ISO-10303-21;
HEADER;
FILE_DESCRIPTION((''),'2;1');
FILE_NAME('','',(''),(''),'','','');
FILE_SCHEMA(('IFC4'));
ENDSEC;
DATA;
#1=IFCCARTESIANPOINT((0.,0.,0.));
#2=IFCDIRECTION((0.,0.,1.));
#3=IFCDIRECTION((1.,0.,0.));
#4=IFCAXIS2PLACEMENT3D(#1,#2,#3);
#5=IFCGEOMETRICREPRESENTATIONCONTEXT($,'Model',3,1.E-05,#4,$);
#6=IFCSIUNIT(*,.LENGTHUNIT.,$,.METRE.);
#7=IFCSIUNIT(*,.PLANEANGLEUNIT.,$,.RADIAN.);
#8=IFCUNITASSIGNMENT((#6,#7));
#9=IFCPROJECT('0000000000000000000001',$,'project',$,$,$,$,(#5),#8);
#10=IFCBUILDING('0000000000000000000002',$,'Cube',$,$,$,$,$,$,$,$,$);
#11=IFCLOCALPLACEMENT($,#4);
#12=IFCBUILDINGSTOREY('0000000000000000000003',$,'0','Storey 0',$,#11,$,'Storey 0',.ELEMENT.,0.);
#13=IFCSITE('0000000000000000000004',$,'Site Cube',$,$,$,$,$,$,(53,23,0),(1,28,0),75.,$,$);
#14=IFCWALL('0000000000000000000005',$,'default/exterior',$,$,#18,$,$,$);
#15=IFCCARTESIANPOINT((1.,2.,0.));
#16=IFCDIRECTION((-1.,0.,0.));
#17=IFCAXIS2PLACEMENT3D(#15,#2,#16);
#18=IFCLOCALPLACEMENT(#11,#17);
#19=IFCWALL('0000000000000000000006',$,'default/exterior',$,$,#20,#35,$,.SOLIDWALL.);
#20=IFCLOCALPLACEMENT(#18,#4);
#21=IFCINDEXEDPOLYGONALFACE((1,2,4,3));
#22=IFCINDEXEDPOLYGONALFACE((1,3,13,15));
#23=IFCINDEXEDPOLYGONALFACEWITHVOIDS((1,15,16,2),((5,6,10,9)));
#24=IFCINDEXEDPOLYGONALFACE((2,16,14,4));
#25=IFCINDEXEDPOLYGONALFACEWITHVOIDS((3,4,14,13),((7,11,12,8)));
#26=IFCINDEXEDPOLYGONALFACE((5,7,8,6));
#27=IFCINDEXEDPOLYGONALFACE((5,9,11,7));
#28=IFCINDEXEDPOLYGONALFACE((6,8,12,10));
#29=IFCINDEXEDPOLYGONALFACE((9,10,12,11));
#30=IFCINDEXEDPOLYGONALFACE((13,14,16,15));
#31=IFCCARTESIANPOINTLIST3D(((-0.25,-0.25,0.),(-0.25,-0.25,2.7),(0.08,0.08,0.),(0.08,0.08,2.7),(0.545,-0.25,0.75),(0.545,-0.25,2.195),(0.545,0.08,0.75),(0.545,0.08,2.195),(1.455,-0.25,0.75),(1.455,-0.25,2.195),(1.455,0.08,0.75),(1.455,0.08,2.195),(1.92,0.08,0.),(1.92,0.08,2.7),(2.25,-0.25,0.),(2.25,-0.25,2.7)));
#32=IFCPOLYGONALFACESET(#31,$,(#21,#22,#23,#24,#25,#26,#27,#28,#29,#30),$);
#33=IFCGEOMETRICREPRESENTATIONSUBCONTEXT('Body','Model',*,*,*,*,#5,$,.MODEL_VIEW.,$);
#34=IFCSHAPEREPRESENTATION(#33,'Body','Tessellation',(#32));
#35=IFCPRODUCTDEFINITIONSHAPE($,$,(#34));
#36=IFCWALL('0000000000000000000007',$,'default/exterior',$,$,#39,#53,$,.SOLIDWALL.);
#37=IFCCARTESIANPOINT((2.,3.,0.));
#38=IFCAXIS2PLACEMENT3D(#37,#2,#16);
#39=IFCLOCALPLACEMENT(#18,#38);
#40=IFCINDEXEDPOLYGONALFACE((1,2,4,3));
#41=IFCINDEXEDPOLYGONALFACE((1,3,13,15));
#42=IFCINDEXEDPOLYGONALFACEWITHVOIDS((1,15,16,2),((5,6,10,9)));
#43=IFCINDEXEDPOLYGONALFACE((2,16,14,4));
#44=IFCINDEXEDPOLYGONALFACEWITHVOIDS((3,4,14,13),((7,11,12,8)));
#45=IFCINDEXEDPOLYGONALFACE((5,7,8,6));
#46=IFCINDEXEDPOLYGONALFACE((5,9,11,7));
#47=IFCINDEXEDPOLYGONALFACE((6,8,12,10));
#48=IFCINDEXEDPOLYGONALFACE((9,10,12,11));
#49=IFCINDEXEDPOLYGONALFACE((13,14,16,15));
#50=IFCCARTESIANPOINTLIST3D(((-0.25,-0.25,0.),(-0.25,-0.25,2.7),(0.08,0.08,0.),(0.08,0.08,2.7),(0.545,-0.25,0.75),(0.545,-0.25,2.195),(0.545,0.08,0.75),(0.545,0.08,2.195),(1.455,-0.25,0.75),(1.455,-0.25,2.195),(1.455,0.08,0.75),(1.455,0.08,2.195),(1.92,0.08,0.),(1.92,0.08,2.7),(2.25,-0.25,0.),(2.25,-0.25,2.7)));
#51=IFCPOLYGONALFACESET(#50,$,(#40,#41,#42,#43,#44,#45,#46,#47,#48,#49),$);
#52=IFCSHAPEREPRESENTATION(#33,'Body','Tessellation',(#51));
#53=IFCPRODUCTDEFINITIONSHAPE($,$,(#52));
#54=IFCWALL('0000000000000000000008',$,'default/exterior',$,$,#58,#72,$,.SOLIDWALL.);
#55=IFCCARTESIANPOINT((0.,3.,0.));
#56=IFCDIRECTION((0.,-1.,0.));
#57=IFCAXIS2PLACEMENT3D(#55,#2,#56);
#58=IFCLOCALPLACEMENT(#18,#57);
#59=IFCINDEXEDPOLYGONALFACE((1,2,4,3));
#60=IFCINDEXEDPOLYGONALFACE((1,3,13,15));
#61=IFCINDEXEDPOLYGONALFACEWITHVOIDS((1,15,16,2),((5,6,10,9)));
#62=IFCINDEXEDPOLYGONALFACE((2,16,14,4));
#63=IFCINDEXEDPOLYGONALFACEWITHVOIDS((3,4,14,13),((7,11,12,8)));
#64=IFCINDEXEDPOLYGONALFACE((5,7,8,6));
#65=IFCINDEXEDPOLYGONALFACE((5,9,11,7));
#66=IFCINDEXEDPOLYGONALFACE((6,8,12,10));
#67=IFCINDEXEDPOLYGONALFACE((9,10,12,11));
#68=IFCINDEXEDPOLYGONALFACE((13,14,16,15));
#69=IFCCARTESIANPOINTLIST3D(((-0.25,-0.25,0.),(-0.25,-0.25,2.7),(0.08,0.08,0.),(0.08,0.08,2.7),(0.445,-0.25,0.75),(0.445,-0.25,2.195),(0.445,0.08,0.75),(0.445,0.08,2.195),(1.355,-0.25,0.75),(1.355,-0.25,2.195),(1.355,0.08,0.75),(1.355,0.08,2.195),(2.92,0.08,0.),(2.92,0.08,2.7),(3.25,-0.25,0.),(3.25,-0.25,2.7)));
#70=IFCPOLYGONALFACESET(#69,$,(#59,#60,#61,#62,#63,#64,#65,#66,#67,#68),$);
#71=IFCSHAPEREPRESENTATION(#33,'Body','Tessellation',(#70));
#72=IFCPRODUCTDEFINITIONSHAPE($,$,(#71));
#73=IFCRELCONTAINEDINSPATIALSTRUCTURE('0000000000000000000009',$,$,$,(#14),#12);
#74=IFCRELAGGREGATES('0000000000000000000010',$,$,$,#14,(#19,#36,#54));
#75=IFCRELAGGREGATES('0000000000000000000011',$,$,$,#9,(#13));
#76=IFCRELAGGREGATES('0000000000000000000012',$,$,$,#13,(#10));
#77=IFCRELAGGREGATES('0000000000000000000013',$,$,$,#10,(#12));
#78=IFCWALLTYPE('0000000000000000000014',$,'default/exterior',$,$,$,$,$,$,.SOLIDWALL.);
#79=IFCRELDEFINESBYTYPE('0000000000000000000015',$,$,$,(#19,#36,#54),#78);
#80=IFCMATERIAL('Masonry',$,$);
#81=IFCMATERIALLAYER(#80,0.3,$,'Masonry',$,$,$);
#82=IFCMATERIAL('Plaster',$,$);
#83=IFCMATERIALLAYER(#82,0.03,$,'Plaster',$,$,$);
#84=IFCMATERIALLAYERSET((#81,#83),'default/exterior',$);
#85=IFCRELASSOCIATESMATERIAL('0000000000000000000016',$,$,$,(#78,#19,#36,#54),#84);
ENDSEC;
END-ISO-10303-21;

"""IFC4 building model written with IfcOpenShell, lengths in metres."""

from ifc_helpers import new_model, si_unit, frame, origin, origin_with_axes, place, context, subcontext, project, spatial, polyline, outline, extrude, material, layer, layer_set, layer_usage, type_object, element, aggregate, save


model = new_model("IFC4")

# Units and contexts
model_context = context("Model", 3, precision=1e-05, world=origin_with_axes())
body_context = subcontext(model_context, "Body", "Model", "MODEL_VIEW")
ifc_project = project(units=[si_unit("LENGTHUNIT", "METRE"), si_unit("PLANEANGLEUNIT", "RADIAN")], contexts=[model_context])

# Site, building, storey
site = spatial("IfcSite", under=ifc_project, Name="Site Cube", RefLatitude=(53, 23, 0), RefLongitude=(1, 28, 0), RefElevation=75.0)
building = spatial("IfcBuilding", under=site, Name="Cube")
storey_placement = place(None, origin_with_axes())
storey = spatial("IfcBuildingStorey", under=building, at=storey_placement, Name="0", Description="Storey 0", LongName="Storey 0", CompositionType="ELEMENT", Elevation=0.0)

# Walls, openings
wall_1_placement = place(storey_placement, frame((1.0, 2.0, 0.0), z_axis=(0.0, 0.0, 1.0), x_axis=(-1.0, 0.0, 0.0)))
wall_1 = element("IfcWall", 1, at=wall_1_placement, inside=storey, Name="default/exterior")
ifc_material_1 = material(Name="Masonry")
ifc_layer_1 = layer(ifc_material_1, 0.3, Name="Masonry")
ifc_material_2 = material(Name="Plaster")
ifc_layer_2 = layer(ifc_material_2, 0.03, Name="Plaster")
ifc_layer_set_1 = layer_set([ifc_layer_1, ifc_layer_2], Name="default/exterior")
ifc_layer_usage_1 = layer_usage(ifc_layer_set_1, "AXIS2", "POSITIVE", -0.25)
wall_type = type_object("IfcWallType", Name="default/exterior", PredefinedType="SOLIDWALL", material=ifc_layer_set_1)
wall_2_placement = place(wall_1_placement, origin_with_axes())
wall_2 = element("IfcWall", 2, at=wall_2_placement, type_object=wall_type, material=ifc_layer_usage_1, Name="default/exterior", PredefinedType="SOLIDWALL", context=body_context, shape_type="SweptSolid", body=[
    extrude(outline(polyline([(0.08, 0.08), (-0.25, -0.25), (2.25, -0.25), (1.92, 0.08), (0.08, 0.08)])), origin(), (0.0, 0.0, 1.0), 2.7),
])
opening_1_placement = place(None, frame((0.455, 2.25, 0.75), z_axis=(0.0, 0.0, 1.0), x_axis=(-1.0, 0.0, 0.0)))
element("IfcOpeningElement", 3, at=opening_1_placement, cuts=wall_2, PredefinedType="OPENING", context=body_context, shape_type="SweptSolid", body=[
    extrude(outline(polyline([(0.0, -0.02), (0.91, -0.02), (0.91, 0.35), (0.0, 0.35), (0.0, -0.02)])), origin(), (0.0, 0.0, 1.0), 1.445),
])
ifc_layer_usage_2 = layer_usage(ifc_layer_set_1, "AXIS2", "POSITIVE", -0.25)
wall_3_placement = place(wall_1_placement, frame((2.0, 3.0, 0.0), z_axis=(0.0, 0.0, 1.0), x_axis=(-1.0, 0.0, 0.0)))
wall_3 = element("IfcWall", 4, at=wall_3_placement, type_object=wall_type, material=ifc_layer_usage_2, Name="default/exterior", PredefinedType="SOLIDWALL", context=body_context, shape_type="SweptSolid", body=[
    extrude(outline(polyline([(0.08, 0.08), (-0.25, -0.25), (2.25, -0.25), (1.92, 0.08), (0.08, 0.08)])), origin(), (0.0, 0.0, 1.0), 2.7),
])
opening_2_placement = place(None, frame((-0.455, -1.25, 0.75), z_axis=(0.0, 0.0, 1.0), x_axis=(1.0, 0.0, 0.0)))
element("IfcOpeningElement", 5, at=opening_2_placement, cuts=wall_3, PredefinedType="OPENING", context=body_context, shape_type="SweptSolid", body=[
    extrude(outline(polyline([(0.0, -0.02), (0.91, -0.02), (0.91, 0.35), (0.0, 0.35), (0.0, -0.02)])), origin(), (0.0, 0.0, 1.0), 1.445),
])
ifc_layer_usage_3 = layer_usage(ifc_layer_set_1, "AXIS2", "POSITIVE", -0.25)
wall_4_placement = place(wall_1_placement, frame((0.0, 3.0, 0.0), z_axis=(0.0, 0.0, 1.0), x_axis=(0.0, -1.0, 0.0)))
wall_4 = element("IfcWall", 6, at=wall_4_placement, type_object=wall_type, material=ifc_layer_usage_3, Name="default/exterior", PredefinedType="SOLIDWALL", context=body_context, shape_type="SweptSolid", body=[
    extrude(outline(polyline([(0.08, 0.08), (-0.25, -0.25), (3.25, -0.25), (2.92, 0.08), (0.08, 0.08)])), origin(), (0.0, 0.0, 1.0), 2.7),
])
opening_3_placement = place(wall_4_placement, frame((0.445, -0.25, 0.75), z_axis=(0.0, 0.0, 1.0), x_axis=(1.0, 0.0, 0.0)))
element("IfcOpeningElement", 7, at=opening_3_placement, cuts=wall_4, PredefinedType="OPENING", context=body_context, shape_type="SweptSolid", body=[
    extrude(outline(polyline([(0.0, -0.02), (0.91, -0.02), (0.91, 0.35), (0.0, 0.35), (0.0, -0.02)])), origin(), (0.0, 0.0, 1.0), 1.445),
])
aggregate(wall_1, [wall_2, wall_3, wall_4])

save(model, "model.ifc")
